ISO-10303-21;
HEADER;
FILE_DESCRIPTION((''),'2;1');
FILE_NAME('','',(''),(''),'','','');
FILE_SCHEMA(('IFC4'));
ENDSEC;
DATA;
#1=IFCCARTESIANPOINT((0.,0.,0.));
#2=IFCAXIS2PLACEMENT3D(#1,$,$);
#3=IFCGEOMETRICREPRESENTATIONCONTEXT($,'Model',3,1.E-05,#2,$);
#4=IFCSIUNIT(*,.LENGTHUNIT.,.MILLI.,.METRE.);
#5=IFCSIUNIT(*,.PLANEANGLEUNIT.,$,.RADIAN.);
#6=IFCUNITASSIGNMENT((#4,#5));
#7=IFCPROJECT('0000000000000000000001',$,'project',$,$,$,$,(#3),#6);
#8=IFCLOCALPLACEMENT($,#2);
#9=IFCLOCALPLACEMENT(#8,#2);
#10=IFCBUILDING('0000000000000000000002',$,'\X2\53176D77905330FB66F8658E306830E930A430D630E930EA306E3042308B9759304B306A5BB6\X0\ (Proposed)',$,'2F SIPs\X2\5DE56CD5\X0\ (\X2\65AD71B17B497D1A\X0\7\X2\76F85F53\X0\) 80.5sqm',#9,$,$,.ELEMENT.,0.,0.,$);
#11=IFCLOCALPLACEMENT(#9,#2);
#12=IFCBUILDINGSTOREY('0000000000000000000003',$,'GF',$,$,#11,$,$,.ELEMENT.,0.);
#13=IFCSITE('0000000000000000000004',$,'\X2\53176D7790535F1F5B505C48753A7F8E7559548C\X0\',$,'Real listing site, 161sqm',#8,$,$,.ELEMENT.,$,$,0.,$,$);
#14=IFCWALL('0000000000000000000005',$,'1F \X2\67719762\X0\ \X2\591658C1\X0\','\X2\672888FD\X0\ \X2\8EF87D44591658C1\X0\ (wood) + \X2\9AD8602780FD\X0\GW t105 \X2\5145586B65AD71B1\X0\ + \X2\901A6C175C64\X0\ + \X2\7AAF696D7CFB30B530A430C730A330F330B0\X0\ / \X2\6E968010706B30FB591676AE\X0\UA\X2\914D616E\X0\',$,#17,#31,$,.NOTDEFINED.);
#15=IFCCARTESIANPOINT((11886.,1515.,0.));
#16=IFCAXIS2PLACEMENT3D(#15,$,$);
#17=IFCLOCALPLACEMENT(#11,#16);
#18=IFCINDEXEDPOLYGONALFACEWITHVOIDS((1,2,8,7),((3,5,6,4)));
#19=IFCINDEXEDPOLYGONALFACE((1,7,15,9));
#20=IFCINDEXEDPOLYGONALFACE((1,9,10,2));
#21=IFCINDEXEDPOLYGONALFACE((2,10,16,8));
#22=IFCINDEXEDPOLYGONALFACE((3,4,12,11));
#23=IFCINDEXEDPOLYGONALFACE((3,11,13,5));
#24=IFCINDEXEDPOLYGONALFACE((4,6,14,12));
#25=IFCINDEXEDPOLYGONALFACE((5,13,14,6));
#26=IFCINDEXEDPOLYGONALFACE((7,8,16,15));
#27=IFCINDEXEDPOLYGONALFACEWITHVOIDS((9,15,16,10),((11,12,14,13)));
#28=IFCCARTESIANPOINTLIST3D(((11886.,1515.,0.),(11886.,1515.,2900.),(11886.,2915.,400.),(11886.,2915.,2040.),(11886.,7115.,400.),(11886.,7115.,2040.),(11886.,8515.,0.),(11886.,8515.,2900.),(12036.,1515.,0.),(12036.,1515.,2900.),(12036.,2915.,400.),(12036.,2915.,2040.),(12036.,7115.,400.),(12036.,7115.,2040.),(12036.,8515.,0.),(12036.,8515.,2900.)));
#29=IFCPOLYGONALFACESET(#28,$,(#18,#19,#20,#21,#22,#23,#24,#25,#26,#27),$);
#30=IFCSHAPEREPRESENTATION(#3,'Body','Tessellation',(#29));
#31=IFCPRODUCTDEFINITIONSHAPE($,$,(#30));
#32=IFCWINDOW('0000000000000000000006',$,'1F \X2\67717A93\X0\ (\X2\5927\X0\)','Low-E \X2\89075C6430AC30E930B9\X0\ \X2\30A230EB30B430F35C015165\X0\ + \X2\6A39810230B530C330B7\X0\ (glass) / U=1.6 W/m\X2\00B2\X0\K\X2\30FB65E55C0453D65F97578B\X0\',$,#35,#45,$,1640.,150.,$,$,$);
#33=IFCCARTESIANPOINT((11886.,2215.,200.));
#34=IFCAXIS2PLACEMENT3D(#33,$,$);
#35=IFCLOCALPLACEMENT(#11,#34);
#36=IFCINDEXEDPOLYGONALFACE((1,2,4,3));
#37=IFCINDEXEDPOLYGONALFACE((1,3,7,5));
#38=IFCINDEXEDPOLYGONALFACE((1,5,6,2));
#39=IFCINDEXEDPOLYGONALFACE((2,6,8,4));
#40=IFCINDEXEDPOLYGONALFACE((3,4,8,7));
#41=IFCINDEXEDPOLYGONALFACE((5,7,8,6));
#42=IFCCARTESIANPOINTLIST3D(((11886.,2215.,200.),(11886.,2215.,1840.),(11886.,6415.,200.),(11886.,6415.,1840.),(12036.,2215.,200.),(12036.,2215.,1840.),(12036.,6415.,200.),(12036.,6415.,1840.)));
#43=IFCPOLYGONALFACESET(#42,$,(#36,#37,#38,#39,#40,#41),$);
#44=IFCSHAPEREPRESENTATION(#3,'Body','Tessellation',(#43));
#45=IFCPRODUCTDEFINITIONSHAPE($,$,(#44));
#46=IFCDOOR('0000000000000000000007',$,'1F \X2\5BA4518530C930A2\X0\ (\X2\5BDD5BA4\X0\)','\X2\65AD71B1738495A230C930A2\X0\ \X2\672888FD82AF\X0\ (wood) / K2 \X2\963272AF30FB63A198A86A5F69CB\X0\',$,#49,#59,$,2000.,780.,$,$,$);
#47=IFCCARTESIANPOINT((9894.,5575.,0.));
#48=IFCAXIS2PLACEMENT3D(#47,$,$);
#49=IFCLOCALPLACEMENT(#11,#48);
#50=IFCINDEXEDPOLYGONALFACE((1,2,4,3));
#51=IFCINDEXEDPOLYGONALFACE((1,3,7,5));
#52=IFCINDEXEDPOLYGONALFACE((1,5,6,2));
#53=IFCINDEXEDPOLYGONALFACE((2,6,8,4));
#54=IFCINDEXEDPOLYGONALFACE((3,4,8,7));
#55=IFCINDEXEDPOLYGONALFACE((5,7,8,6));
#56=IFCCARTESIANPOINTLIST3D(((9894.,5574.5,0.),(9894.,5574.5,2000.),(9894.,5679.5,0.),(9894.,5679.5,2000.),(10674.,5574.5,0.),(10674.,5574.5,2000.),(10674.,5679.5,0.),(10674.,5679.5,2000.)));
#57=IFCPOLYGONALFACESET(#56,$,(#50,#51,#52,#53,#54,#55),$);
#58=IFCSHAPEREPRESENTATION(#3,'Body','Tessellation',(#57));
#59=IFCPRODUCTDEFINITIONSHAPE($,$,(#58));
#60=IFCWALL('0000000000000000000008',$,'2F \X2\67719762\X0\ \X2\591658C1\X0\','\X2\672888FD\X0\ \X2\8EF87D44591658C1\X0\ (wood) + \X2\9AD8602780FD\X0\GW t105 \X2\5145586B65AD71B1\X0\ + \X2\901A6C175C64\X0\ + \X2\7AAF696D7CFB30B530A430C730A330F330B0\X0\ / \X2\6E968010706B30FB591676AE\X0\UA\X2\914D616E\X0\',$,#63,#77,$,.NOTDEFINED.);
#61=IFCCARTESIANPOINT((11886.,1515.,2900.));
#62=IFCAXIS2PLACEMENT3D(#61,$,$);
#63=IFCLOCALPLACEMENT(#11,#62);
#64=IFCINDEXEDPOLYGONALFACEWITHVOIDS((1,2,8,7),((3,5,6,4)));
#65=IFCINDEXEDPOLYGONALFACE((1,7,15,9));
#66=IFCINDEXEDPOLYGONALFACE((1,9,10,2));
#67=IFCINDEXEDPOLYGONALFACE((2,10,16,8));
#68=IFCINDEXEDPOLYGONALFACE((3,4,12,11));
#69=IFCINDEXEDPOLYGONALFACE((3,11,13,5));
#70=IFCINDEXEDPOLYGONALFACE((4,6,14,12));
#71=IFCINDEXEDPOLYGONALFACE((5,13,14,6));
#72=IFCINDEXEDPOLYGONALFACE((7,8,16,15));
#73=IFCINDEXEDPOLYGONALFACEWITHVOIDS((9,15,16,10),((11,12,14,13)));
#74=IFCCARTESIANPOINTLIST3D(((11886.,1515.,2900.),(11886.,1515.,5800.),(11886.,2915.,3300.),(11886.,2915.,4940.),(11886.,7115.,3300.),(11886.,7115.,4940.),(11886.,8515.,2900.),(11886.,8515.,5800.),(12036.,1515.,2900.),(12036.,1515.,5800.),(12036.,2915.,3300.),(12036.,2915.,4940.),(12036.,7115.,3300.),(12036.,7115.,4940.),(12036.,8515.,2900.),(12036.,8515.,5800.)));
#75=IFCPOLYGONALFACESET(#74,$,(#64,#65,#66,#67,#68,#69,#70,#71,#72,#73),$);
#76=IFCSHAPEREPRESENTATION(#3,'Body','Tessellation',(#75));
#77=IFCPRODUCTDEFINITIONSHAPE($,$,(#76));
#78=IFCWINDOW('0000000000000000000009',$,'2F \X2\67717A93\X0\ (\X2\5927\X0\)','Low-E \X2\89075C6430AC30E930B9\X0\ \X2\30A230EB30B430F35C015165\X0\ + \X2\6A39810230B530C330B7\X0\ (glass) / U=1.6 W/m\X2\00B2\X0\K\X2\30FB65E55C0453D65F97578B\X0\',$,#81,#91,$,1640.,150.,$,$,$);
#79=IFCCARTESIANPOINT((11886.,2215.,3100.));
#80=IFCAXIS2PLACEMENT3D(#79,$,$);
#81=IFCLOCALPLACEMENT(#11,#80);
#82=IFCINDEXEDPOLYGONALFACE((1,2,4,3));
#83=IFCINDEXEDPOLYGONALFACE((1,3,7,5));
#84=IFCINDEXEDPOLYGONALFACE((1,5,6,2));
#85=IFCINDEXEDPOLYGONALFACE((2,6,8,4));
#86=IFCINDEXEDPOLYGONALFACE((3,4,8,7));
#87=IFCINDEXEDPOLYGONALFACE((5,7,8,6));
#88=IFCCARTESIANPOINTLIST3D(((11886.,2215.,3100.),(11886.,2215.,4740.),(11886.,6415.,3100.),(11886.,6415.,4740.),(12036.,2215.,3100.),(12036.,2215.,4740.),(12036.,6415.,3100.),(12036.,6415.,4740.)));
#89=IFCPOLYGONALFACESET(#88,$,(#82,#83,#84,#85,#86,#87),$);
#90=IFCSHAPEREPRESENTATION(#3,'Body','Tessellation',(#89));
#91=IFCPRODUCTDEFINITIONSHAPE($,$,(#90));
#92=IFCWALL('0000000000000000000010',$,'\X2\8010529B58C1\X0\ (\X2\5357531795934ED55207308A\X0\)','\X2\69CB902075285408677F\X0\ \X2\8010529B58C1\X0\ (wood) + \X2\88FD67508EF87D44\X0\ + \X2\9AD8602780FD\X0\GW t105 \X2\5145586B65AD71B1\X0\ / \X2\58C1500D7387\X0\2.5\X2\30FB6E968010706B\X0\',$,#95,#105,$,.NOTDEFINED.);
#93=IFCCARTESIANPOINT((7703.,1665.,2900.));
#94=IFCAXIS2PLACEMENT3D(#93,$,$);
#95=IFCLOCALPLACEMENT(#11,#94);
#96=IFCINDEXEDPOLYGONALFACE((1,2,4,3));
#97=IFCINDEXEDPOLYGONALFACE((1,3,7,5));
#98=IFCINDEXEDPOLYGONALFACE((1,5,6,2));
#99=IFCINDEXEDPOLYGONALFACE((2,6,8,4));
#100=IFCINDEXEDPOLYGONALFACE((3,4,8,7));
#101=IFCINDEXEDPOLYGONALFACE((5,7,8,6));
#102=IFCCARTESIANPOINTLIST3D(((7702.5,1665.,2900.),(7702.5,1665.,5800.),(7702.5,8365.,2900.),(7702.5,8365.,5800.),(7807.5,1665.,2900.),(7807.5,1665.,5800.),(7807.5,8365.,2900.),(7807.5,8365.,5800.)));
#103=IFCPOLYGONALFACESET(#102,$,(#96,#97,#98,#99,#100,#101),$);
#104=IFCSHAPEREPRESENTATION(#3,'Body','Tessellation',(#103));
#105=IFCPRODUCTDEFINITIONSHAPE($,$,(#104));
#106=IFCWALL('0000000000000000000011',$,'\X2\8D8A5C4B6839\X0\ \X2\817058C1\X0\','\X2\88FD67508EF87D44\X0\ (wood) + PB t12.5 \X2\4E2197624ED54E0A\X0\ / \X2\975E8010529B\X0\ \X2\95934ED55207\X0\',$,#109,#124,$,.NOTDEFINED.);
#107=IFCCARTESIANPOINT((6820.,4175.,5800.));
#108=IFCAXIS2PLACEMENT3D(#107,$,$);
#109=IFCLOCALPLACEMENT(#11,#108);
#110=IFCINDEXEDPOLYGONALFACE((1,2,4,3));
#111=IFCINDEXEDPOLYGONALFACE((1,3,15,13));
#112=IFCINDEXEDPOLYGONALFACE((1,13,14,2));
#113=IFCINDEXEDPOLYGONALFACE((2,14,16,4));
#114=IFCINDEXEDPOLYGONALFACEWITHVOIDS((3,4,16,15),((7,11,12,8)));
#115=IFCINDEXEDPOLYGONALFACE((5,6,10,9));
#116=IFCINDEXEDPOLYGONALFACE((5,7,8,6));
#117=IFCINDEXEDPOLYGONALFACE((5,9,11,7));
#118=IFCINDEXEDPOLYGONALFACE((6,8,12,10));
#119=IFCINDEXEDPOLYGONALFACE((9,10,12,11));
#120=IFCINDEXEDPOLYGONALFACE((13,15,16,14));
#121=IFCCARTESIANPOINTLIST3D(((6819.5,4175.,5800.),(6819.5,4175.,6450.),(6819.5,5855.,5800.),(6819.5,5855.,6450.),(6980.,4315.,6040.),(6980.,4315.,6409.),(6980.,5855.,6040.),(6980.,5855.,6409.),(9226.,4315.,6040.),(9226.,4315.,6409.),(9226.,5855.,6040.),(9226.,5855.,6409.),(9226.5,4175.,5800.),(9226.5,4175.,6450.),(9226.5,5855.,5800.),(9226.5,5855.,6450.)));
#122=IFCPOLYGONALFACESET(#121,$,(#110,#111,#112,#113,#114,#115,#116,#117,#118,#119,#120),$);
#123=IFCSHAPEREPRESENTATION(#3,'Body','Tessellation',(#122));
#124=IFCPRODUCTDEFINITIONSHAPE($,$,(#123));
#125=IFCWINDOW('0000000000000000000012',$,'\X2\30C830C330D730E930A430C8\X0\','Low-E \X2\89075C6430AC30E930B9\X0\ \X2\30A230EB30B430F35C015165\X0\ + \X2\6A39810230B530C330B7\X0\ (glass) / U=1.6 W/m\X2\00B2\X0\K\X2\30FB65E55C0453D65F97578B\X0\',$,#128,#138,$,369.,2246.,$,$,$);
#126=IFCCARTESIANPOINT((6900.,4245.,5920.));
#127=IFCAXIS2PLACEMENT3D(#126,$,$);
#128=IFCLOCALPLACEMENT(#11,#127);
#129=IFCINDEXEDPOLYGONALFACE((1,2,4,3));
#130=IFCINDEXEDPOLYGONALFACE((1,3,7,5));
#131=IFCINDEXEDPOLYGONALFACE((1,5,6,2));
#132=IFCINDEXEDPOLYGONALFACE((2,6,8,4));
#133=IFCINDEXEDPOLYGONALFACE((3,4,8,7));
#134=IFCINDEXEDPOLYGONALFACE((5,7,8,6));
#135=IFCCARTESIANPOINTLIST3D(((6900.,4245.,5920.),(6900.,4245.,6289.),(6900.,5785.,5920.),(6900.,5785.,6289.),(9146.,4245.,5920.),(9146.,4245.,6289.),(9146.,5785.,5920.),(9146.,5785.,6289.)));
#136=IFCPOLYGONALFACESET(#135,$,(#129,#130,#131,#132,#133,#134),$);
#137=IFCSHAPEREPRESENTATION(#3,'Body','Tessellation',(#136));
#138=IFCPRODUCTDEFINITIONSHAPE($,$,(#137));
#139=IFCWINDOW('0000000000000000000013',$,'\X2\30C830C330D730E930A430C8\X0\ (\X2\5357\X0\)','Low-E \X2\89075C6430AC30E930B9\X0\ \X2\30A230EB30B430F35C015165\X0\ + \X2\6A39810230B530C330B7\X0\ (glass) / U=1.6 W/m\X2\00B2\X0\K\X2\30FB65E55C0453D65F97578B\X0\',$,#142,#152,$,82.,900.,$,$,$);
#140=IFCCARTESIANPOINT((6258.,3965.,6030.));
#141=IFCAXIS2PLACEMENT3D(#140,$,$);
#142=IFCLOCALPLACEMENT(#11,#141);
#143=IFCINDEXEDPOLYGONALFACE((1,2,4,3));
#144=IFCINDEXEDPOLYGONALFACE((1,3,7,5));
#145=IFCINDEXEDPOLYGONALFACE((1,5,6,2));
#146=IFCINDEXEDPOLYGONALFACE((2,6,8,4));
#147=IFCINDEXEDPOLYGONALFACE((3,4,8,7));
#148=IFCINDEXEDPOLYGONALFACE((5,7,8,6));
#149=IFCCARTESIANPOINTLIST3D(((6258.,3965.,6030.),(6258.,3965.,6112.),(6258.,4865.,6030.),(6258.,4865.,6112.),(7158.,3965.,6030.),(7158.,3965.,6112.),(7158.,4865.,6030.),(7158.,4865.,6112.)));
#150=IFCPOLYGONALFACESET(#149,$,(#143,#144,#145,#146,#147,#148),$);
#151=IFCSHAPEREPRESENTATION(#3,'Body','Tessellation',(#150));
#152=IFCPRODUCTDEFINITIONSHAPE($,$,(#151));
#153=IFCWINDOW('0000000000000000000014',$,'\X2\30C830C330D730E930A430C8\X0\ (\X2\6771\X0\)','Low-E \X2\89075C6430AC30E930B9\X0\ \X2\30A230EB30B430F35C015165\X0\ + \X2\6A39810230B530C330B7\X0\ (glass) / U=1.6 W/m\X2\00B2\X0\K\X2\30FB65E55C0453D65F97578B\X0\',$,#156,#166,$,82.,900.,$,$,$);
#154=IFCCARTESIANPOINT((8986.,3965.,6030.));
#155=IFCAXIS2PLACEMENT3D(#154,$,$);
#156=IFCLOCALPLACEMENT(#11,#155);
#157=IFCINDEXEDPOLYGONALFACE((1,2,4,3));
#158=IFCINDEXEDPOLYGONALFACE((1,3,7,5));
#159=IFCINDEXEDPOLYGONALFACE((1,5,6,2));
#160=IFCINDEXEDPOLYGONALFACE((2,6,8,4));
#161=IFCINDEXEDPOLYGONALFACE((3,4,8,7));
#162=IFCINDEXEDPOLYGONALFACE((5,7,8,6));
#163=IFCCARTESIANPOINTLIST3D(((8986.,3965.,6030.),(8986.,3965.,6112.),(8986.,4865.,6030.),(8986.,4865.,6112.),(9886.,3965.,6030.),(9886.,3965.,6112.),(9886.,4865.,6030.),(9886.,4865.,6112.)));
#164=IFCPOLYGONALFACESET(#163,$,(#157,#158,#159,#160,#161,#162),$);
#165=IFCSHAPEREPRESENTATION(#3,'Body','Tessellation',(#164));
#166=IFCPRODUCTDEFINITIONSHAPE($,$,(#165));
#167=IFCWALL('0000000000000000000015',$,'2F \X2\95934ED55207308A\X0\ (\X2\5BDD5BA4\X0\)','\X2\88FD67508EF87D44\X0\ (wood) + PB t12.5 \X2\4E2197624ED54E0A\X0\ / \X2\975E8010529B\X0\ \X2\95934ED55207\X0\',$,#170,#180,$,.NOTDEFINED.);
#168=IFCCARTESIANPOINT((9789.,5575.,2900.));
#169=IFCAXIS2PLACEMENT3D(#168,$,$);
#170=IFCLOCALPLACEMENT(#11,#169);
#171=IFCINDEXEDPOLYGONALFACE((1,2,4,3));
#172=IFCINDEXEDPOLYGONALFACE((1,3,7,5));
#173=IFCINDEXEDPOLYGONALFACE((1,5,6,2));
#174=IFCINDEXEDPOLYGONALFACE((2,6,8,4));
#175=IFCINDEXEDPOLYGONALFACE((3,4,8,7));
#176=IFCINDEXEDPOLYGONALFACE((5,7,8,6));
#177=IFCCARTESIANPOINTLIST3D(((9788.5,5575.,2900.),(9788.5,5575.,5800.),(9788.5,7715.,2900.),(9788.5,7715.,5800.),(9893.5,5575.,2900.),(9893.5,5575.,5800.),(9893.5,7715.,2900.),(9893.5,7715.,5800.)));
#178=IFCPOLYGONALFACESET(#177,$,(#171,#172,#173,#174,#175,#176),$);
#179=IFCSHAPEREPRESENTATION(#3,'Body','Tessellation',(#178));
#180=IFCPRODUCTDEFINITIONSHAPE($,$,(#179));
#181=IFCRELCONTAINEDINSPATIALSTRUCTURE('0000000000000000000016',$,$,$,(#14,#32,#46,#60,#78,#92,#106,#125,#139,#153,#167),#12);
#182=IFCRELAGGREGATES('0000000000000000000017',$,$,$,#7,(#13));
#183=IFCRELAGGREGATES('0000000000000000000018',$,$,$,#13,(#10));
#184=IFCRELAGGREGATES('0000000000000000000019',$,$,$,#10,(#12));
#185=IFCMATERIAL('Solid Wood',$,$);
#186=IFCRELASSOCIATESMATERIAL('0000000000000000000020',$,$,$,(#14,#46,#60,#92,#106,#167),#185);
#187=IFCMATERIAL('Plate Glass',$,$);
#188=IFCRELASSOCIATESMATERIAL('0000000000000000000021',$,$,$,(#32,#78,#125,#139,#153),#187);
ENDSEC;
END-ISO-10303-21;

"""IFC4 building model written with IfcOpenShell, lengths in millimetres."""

from ifc_helpers import new_model, si_unit, frame, frame_2d, origin, place, context, project, spatial, rectangle, extrude, material, element, fill, save


model = new_model("IFC4")

# Units and contexts
model_context = context("Model", 3, precision=1e-05, world=origin())
ifc_project = project(units=[si_unit("LENGTHUNIT", "METRE", prefix="MILLI"), si_unit("PLANEANGLEUNIT", "RADIAN")], contexts=[model_context])

# Site, building, storey
site_placement = place(None, origin())
site = spatial("IfcSite", under=ifc_project, at=site_placement, Name="北海道弟子屈町美留和", ObjectType="Real listing site, 161sqm", CompositionType="ELEMENT", RefElevation=0.0)
building_placement = place(site_placement, origin())
building = spatial("IfcBuilding", under=site, at=building_placement, Name="北海道・書斎とライブラリのある静かな家 (Proposed)", ObjectType="2F SIPs工法 (断熱等級7相当) 80.5sqm", CompositionType="ELEMENT", ElevationOfRefHeight=0.0, ElevationOfTerrain=0.0)
storey_placement = place(building_placement, origin())
storey = spatial("IfcBuildingStorey", under=building, at=storey_placement, Name="GF", CompositionType="ELEMENT", Elevation=0.0)

# Wall, opening, window
ifc_material_1 = material(Name="Solid Wood")
wall_1_placement = place(storey_placement, frame((11886.0, 1515.0, 0.0)))
wall_1 = element("IfcWall", 1, at=wall_1_placement, inside=storey, material=ifc_material_1, Name="1F 東面 外壁", Description="木製 軸組外壁 (wood) + 高性能GW t105 充填断熱 + 通気層 + 窯業系サイディング / 準耐火・外皮UA配慮", PredefinedType="NOTDEFINED", context=model_context, shape_type="SweptSolid", body=[
    extrude(rectangle(XDim=150.0, YDim=7000.0, at=frame_2d((75.0, 3500.0))), frame((11886.0, 1515.0, 0.0)), (0.0, 0.0, 1.0), 2900.0),
])
opening_1_placement = place(storey_placement, frame((11886.0, 2215.0, 200.0)))
opening_1 = element("IfcOpeningElement", 2, at=opening_1_placement, cuts=wall_1, PredefinedType="NOTDEFINED", context=model_context, shape_type="SweptSolid", body=[
    extrude(rectangle(XDim=150.0, YDim=4200.0, at=frame_2d((75.0, 2100.0))), frame((11886.0, 2215.0, 200.0)), (0.0, 0.0, 1.0), 1640.0),
])
ifc_material_2 = material(Name="Plate Glass")
window_1_placement = place(storey_placement, frame((11886.0, 2215.0, 200.0)))
window_1 = element("IfcWindow", 3, at=window_1_placement, inside=storey, material=ifc_material_2, Name="1F 東窓 (大)", Description="Low-E 複層ガラス アルゴン封入 + 樹脂サッシ (glass) / U=1.6 W/m²K・日射取得型", OverallHeight=1640.0, OverallWidth=150.0, context=model_context, shape_type="SweptSolid", body=[
    extrude(rectangle(XDim=150.0, YDim=4200.0, at=frame_2d((75.0, 2100.0))), frame((11886.0, 2215.0, 200.0)), (0.0, 0.0, 1.0), 1640.0),
])
fill(opening_1, window_1)

# Door
door_1_placement = place(storey_placement, frame((9894.0, 5575.0, 0.0)))
element("IfcDoor", 4, at=door_1_placement, inside=storey, material=ifc_material_1, Name="1F 室内ドア (寝室)", Description="断熱玄関ドア 木製芯 (wood) / K2 防犯・採風機構", OverallHeight=2000.0, OverallWidth=780.0, context=model_context, shape_type="SweptSolid", body=[
    extrude(rectangle(XDim=780.0, YDim=105.0, at=frame_2d((390.0, 52.0))), frame((9894.0, 5575.0, 0.0)), (0.0, 0.0, 1.0), 2000.0),
])

# Wall, opening, window
wall_2_placement = place(storey_placement, frame((11886.0, 1515.0, 2900.0)))
wall_2 = element("IfcWall", 5, at=wall_2_placement, inside=storey, material=ifc_material_1, Name="2F 東面 外壁", Description="木製 軸組外壁 (wood) + 高性能GW t105 充填断熱 + 通気層 + 窯業系サイディング / 準耐火・外皮UA配慮", PredefinedType="NOTDEFINED", context=model_context, shape_type="SweptSolid", body=[
    extrude(rectangle(XDim=150.0, YDim=7000.0, at=frame_2d((75.0, 3500.0))), frame((11886.0, 1515.0, 2900.0)), (0.0, 0.0, 1.0), 2900.0),
])
opening_2_placement = place(storey_placement, frame((11886.0, 2215.0, 3100.0)))
opening_2 = element("IfcOpeningElement", 6, at=opening_2_placement, cuts=wall_2, PredefinedType="NOTDEFINED", context=model_context, shape_type="SweptSolid", body=[
    extrude(rectangle(XDim=150.0, YDim=4200.0, at=frame_2d((75.0, 2100.0))), frame((11886.0, 2215.0, 3100.0)), (0.0, 0.0, 1.0), 1640.0),
])
window_2_placement = place(storey_placement, frame((11886.0, 2215.0, 3100.0)))
window_2 = element("IfcWindow", 7, at=window_2_placement, inside=storey, material=ifc_material_2, Name="2F 東窓 (大)", Description="Low-E 複層ガラス アルゴン封入 + 樹脂サッシ (glass) / U=1.6 W/m²K・日射取得型", OverallHeight=1640.0, OverallWidth=150.0, context=model_context, shape_type="SweptSolid", body=[
    extrude(rectangle(XDim=150.0, YDim=4200.0, at=frame_2d((75.0, 2100.0))), frame((11886.0, 2215.0, 3100.0)), (0.0, 0.0, 1.0), 1640.0),
])
fill(opening_2, window_2)

# Wall
wall_3_placement = place(storey_placement, frame((7703.0, 1665.0, 2900.0)))
element("IfcWall", 8, at=wall_3_placement, inside=storey, material=ifc_material_1, Name="耐力壁 (南北間仕切り)", Description="構造用合板 耐力壁 (wood) + 製材軸組 + 高性能GW t105 充填断熱 / 壁倍率2.5・準耐火", PredefinedType="NOTDEFINED", context=model_context, shape_type="SweptSolid", body=[
    extrude(rectangle(XDim=105.0, YDim=6700.0, at=frame_2d((52.0, 3350.0))), frame((7703.0, 1665.0, 2900.0)), (0.0, 0.0, 1.0), 2900.0),
])

# Wall, openings, windows
wall_4_placement = place(storey_placement, frame((6820.0, 4175.0, 5800.0)))
wall_4 = element("IfcWall", 9, at=wall_4_placement, inside=storey, material=ifc_material_1, Name="越屋根 腰壁", Description="製材軸組 (wood) + PB t12.5 両面仕上 / 非耐力 間仕切", PredefinedType="NOTDEFINED", context=model_context, shape_type="SweptSolid", body=[
    extrude(rectangle(XDim=2407.0, YDim=1680.0, at=frame_2d((1203.0, 840.0))), frame((6820.0, 4175.0, 5800.0)), (0.0, 0.0, 1.0), 650.0),
])
opening_3_placement = place(storey_placement, frame((6900.0, 4245.0, 5920.0)))
opening_3 = element("IfcOpeningElement", 10, at=opening_3_placement, cuts=wall_4, PredefinedType="NOTDEFINED", context=model_context, shape_type="SweptSolid", body=[
    extrude(rectangle(XDim=2246.0, YDim=1540.0, at=frame_2d((1123.0, 770.0))), frame((6900.0, 4245.0, 5920.0)), (0.0, 0.0, 1.0), 369.0),
])
opening_4_placement = place(storey_placement, frame((6258.0, 3965.0, 6030.0)))
opening_4 = element("IfcOpeningElement", 11, at=opening_4_placement, cuts=wall_4, PredefinedType="NOTDEFINED", context=model_context, shape_type="SweptSolid", body=[
    extrude(rectangle(XDim=900.0, YDim=900.0, at=frame_2d((450.0, 450.0))), frame((6258.0, 3965.0, 6030.0)), (0.0, 0.0, 1.0), 82.0),
])
opening_5_placement = place(storey_placement, frame((8986.0, 3965.0, 6030.0)))
opening_5 = element("IfcOpeningElement", 12, at=opening_5_placement, cuts=wall_4, PredefinedType="NOTDEFINED", context=model_context, shape_type="SweptSolid", body=[
    extrude(rectangle(XDim=900.0, YDim=900.0, at=frame_2d((450.0, 450.0))), frame((8986.0, 3965.0, 6030.0)), (0.0, 0.0, 1.0), 82.0),
])
window_3_placement = place(storey_placement, frame((6900.0, 4245.0, 5920.0)))
window_3 = element("IfcWindow", 13, at=window_3_placement, inside=storey, material=ifc_material_2, Name="トップライト", Description="Low-E 複層ガラス アルゴン封入 + 樹脂サッシ (glass) / U=1.6 W/m²K・日射取得型", OverallHeight=369.0, OverallWidth=2246.0, context=model_context, shape_type="SweptSolid", body=[
    extrude(rectangle(XDim=2246.0, YDim=1540.0, at=frame_2d((1123.0, 770.0))), frame((6900.0, 4245.0, 5920.0)), (0.0, 0.0, 1.0), 369.0),
])
fill(opening_3, window_3)
window_4_placement = place(storey_placement, frame((6258.0, 3965.0, 6030.0)))
window_4 = element("IfcWindow", 14, at=window_4_placement, inside=storey, material=ifc_material_2, Name="トップライト (南)", Description="Low-E 複層ガラス アルゴン封入 + 樹脂サッシ (glass) / U=1.6 W/m²K・日射取得型", OverallHeight=82.0, OverallWidth=900.0, context=model_context, shape_type="SweptSolid", body=[
    extrude(rectangle(XDim=900.0, YDim=900.0, at=frame_2d((450.0, 450.0))), frame((6258.0, 3965.0, 6030.0)), (0.0, 0.0, 1.0), 82.0),
])
fill(opening_4, window_4)
window_5_placement = place(storey_placement, frame((8986.0, 3965.0, 6030.0)))
window_5 = element("IfcWindow", 15, at=window_5_placement, inside=storey, material=ifc_material_2, Name="トップライト (東)", Description="Low-E 複層ガラス アルゴン封入 + 樹脂サッシ (glass) / U=1.6 W/m²K・日射取得型", OverallHeight=82.0, OverallWidth=900.0, context=model_context, shape_type="SweptSolid", body=[
    extrude(rectangle(XDim=900.0, YDim=900.0, at=frame_2d((450.0, 450.0))), frame((8986.0, 3965.0, 6030.0)), (0.0, 0.0, 1.0), 82.0),
])
fill(opening_5, window_5)

# Wall
wall_5_placement = place(storey_placement, frame((9789.0, 5575.0, 2900.0)))
element("IfcWall", 16, at=wall_5_placement, inside=storey, material=ifc_material_1, Name="2F 間仕切り (寝室)", Description="製材軸組 (wood) + PB t12.5 両面仕上 / 非耐力 間仕切", PredefinedType="NOTDEFINED", context=model_context, shape_type="SweptSolid", body=[
    extrude(rectangle(XDim=105.0, YDim=2140.0, at=frame_2d((52.0, 1070.0))), frame((9789.0, 5575.0, 2900.0)), (0.0, 0.0, 1.0), 2900.0),
])

save(model, "model.ifc")
